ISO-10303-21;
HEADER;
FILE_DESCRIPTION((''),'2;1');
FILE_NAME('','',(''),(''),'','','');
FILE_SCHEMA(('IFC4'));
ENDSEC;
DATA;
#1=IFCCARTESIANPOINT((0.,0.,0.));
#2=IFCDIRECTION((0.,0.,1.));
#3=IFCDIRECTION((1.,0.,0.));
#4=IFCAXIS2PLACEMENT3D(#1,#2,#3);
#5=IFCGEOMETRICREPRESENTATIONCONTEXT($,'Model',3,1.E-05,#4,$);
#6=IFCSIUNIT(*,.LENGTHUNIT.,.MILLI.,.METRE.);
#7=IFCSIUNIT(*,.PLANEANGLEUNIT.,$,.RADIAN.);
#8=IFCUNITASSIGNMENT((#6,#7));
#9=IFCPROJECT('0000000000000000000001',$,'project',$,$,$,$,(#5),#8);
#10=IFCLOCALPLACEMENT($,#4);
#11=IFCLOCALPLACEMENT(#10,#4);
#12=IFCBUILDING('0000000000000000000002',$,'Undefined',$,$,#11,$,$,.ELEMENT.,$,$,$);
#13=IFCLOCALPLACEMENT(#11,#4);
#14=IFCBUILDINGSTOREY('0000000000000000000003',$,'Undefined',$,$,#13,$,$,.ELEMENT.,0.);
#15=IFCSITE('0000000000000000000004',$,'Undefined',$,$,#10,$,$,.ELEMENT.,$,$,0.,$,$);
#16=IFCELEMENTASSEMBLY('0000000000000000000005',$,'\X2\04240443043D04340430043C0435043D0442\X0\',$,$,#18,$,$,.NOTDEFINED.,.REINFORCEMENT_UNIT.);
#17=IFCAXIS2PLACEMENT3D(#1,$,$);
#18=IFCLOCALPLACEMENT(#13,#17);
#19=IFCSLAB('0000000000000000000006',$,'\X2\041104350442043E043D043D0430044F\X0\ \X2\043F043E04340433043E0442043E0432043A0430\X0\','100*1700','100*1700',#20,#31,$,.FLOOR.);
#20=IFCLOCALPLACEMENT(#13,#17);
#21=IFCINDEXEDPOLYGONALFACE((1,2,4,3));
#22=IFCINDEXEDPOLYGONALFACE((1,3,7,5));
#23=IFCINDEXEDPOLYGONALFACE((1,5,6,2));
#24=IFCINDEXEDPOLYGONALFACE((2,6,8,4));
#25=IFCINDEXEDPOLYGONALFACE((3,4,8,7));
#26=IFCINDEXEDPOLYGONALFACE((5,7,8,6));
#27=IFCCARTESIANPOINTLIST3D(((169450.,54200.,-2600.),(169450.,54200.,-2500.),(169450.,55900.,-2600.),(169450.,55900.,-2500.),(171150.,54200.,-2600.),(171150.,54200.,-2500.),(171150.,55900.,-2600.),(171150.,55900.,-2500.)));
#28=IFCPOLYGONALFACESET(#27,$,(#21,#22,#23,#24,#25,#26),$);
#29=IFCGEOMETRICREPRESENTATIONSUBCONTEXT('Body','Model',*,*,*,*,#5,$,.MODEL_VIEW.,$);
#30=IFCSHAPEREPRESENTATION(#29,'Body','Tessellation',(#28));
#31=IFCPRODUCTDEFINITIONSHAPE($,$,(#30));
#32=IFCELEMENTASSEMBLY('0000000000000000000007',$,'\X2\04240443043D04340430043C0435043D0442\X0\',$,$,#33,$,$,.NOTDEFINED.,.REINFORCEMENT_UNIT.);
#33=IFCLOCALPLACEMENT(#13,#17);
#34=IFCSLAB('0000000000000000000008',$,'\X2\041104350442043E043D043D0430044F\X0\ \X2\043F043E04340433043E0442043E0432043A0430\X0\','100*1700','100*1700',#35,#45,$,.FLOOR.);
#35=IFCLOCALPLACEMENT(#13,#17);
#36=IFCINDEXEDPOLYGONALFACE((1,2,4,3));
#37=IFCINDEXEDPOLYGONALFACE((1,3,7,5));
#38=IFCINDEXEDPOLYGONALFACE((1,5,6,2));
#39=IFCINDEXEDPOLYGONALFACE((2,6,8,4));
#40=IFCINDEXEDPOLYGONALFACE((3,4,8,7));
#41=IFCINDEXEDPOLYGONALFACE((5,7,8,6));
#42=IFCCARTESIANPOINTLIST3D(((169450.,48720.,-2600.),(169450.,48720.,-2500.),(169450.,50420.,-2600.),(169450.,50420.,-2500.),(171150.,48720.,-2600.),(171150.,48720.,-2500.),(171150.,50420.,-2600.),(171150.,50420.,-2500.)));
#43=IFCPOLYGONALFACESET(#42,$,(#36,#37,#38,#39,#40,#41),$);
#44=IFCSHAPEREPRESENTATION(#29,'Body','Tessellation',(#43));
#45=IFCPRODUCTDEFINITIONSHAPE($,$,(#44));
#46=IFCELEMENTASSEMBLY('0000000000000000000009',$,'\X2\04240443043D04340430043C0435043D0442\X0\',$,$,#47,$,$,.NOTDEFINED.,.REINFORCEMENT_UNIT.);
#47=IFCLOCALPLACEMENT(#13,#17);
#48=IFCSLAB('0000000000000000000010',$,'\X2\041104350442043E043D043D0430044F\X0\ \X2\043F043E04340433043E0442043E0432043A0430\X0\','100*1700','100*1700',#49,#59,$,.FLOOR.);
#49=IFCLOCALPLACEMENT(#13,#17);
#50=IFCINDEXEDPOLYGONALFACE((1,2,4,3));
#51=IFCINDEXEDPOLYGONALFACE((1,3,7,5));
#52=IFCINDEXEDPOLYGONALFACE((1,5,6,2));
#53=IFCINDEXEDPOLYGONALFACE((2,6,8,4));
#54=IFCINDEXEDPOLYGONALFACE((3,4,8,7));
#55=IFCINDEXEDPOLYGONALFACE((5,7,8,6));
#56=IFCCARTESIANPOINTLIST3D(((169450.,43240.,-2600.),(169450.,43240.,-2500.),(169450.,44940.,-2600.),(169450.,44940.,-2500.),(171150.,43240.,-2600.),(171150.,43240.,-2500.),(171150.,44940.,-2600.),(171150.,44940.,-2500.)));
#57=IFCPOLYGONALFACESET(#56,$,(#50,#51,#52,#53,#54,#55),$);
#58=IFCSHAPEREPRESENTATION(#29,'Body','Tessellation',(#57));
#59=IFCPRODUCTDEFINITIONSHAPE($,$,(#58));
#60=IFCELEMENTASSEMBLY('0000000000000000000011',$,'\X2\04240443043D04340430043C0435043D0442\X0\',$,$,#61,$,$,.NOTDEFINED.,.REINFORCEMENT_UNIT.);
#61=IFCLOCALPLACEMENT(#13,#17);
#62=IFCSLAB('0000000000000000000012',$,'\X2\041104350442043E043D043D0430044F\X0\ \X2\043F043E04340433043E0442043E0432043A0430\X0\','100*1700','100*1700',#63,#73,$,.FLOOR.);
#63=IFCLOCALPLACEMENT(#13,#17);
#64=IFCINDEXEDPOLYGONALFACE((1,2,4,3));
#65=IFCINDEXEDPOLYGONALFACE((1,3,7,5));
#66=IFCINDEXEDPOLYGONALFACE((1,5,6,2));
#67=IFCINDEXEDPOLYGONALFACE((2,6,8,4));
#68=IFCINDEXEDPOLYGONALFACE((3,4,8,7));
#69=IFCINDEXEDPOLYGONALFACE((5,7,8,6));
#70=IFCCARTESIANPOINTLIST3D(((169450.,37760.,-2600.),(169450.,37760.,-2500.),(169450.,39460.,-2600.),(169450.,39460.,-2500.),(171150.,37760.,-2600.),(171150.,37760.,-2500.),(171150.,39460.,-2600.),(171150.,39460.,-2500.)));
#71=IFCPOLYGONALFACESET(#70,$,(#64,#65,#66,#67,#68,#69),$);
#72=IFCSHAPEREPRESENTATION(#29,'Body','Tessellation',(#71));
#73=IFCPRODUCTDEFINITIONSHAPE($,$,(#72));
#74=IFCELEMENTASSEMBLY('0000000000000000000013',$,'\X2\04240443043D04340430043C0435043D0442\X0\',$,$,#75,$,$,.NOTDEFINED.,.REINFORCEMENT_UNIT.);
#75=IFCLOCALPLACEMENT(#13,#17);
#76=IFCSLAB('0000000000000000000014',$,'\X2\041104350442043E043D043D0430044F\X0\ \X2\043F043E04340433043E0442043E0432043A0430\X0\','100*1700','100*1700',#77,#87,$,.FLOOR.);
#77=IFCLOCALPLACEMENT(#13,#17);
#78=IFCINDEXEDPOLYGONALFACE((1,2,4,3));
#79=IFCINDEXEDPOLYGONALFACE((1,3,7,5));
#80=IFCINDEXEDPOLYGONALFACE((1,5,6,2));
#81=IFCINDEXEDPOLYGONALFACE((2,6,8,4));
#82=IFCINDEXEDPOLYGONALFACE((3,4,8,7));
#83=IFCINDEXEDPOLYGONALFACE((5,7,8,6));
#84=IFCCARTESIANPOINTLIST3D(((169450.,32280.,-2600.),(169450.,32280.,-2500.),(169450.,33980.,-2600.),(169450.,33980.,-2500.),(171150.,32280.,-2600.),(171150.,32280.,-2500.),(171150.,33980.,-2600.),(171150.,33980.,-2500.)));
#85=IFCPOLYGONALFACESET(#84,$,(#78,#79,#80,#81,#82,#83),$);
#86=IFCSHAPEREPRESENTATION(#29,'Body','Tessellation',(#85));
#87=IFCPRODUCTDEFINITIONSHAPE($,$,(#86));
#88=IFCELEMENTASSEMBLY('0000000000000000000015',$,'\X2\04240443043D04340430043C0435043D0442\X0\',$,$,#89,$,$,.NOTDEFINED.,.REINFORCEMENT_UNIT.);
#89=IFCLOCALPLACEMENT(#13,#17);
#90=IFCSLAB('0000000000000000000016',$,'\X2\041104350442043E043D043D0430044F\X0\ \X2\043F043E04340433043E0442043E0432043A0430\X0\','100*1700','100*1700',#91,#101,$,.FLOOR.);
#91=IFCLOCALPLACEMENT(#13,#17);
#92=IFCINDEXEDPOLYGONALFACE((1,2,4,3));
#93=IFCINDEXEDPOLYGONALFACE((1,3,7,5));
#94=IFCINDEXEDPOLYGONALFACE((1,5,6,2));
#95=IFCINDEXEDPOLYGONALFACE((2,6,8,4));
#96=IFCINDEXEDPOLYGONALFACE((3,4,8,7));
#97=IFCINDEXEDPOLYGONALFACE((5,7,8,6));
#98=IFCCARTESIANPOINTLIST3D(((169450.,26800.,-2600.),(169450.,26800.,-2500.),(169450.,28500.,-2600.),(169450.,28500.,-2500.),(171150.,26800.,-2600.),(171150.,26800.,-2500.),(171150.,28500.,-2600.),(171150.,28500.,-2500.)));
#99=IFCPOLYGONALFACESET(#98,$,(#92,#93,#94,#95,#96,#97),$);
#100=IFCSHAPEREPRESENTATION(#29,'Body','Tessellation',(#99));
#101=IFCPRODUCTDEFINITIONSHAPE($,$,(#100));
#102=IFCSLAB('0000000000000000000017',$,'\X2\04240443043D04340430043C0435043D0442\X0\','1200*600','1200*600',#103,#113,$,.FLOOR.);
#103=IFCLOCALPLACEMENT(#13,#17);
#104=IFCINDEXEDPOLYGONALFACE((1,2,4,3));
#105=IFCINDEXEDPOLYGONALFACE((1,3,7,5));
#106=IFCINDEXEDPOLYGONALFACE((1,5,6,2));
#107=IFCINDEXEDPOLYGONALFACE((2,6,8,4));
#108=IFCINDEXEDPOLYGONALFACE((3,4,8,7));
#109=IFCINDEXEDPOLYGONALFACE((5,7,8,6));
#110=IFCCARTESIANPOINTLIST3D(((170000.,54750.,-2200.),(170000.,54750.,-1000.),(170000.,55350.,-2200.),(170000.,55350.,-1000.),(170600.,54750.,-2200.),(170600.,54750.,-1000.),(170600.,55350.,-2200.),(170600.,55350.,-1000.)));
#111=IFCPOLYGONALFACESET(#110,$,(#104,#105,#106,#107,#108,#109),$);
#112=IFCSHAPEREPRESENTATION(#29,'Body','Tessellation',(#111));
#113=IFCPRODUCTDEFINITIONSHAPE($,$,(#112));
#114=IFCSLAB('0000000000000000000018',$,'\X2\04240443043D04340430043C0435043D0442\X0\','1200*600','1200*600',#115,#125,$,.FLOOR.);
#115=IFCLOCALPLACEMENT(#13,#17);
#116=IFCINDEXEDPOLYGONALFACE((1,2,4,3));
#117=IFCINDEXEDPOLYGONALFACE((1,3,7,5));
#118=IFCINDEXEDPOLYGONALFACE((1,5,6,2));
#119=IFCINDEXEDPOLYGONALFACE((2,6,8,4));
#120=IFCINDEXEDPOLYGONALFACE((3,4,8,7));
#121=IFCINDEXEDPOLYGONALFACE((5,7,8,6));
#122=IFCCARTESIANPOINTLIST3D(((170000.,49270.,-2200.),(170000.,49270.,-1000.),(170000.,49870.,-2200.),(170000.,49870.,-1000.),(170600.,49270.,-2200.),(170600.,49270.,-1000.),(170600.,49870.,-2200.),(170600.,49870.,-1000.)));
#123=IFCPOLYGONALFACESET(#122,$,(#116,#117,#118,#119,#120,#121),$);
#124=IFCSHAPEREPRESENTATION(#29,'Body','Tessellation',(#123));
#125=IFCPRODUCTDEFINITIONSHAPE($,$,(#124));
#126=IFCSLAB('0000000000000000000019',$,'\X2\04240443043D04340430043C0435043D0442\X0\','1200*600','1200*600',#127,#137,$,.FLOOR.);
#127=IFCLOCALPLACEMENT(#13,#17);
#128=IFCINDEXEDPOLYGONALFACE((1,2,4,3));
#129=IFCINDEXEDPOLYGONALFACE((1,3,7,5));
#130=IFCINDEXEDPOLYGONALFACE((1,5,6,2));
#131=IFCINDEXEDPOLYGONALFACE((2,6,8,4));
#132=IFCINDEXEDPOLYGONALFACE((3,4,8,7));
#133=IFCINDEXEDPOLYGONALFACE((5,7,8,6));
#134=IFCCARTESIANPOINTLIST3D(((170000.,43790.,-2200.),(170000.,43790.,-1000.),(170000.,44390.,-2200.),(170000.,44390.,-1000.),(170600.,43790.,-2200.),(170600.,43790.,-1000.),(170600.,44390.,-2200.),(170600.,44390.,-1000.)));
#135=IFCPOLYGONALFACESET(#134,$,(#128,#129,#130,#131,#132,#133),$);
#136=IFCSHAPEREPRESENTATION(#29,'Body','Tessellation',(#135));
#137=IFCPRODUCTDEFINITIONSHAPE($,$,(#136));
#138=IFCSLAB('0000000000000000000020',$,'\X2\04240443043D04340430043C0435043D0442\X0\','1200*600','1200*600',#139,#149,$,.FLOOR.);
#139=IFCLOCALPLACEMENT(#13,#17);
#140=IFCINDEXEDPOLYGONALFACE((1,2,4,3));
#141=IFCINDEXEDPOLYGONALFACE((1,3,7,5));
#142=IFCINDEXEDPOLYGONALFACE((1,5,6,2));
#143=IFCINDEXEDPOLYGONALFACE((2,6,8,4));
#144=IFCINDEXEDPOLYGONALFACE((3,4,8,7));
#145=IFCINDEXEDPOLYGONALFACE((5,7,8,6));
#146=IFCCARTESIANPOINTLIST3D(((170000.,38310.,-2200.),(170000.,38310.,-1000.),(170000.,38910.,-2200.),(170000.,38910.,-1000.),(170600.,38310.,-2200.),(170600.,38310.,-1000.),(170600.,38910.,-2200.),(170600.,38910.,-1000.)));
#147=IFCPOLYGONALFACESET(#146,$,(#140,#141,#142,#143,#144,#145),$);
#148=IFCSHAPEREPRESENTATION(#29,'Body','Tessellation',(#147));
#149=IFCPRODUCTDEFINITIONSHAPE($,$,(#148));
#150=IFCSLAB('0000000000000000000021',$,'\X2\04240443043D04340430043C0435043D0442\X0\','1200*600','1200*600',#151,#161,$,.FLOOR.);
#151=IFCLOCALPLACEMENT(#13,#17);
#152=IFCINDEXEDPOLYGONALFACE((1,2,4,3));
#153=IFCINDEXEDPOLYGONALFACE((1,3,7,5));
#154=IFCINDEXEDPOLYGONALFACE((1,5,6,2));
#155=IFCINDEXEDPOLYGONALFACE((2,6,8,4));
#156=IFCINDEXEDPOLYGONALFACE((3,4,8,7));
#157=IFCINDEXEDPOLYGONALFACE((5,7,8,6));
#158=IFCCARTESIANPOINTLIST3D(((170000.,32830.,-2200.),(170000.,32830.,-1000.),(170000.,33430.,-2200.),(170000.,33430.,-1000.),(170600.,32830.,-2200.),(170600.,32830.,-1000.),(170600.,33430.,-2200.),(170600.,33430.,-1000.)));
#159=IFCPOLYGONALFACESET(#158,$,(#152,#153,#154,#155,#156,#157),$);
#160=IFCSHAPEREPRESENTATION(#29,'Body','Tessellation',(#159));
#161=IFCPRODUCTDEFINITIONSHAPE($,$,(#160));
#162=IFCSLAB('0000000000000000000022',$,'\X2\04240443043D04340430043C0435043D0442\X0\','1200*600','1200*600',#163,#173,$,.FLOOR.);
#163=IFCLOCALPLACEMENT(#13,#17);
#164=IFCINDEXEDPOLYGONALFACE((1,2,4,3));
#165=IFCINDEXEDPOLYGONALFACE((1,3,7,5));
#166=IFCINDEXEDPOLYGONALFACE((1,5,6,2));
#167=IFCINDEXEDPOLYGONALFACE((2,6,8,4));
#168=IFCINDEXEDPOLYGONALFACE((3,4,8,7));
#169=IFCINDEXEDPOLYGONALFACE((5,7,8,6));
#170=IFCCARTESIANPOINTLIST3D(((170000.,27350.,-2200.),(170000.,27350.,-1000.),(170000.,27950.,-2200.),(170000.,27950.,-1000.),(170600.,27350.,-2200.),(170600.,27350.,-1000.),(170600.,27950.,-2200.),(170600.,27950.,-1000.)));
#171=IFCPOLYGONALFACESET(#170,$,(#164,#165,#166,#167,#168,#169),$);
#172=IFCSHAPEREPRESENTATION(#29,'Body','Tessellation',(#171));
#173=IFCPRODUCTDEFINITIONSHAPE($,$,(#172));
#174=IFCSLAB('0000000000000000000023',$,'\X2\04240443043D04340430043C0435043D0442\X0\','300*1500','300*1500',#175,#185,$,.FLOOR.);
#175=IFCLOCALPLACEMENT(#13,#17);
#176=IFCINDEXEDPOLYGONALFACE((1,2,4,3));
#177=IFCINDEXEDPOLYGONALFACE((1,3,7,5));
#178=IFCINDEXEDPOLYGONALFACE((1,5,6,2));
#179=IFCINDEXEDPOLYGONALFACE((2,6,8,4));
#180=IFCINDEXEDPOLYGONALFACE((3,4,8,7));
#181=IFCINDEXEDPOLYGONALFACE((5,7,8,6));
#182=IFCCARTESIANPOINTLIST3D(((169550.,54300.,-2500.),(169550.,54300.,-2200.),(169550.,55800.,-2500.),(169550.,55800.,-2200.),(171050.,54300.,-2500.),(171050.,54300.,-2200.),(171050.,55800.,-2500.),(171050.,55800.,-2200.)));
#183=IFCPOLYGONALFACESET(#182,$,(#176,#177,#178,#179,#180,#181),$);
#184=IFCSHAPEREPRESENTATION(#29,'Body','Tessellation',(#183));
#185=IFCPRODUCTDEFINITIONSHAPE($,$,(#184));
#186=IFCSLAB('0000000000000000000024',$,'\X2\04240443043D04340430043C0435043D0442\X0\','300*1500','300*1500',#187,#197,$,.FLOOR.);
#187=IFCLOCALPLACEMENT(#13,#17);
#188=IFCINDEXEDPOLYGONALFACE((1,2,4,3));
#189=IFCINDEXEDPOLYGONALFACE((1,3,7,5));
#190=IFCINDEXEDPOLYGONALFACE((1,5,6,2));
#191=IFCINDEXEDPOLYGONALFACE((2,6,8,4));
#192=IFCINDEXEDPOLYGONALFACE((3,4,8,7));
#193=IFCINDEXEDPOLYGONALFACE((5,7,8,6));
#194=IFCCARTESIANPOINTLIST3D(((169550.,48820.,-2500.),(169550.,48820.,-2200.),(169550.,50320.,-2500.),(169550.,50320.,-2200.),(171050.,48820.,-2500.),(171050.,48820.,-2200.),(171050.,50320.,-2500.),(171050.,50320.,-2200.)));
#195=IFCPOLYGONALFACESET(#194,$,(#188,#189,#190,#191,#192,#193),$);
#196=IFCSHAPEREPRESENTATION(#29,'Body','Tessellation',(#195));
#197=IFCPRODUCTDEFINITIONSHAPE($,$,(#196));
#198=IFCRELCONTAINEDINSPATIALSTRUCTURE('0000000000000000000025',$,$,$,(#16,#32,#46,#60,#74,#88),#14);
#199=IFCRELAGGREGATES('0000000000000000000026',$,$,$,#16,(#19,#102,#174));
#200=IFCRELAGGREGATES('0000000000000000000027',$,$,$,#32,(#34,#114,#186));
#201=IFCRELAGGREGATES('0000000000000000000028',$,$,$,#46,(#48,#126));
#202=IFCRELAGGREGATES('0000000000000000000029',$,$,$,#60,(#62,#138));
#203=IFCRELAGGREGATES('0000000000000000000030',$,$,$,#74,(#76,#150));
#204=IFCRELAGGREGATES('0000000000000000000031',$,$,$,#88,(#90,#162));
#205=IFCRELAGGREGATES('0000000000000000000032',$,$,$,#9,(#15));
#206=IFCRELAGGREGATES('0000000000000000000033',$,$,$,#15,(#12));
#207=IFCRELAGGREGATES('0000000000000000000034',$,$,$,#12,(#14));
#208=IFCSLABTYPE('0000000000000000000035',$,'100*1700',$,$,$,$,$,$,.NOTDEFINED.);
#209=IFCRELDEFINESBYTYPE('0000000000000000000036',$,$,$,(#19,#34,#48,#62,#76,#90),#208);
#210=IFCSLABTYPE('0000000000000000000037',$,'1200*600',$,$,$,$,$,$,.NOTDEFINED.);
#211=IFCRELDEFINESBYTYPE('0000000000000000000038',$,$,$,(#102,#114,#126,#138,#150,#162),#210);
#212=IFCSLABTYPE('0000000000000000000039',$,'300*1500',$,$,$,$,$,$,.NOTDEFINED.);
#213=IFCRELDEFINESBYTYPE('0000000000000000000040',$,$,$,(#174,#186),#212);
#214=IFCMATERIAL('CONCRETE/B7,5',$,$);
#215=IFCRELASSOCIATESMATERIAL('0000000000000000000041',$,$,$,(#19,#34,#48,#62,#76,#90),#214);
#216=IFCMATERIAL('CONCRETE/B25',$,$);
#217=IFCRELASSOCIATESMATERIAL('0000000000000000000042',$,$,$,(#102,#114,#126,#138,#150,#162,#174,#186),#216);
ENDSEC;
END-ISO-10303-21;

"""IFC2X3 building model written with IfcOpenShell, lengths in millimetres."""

from ifc_helpers import new_model, si_unit, frame, origin_with_axes, place, context, subcontext, project, spatial, polyline, outline, extrude, material, type_object, element, aggregate, save


model = new_model("IFC2X3")

# Units and contexts
model_context = context("Model", 3, precision=1e-05, world=origin_with_axes())
body_context = subcontext(model_context, "Body", "Model", "MODEL_VIEW")
ifc_project = project(units=[si_unit("LENGTHUNIT", "METRE", prefix="MILLI"), si_unit("PLANEANGLEUNIT", "RADIAN")], contexts=[model_context])

# Site, building, storey
site_placement = place(None, origin_with_axes())
site = spatial("IfcSite", under=ifc_project, at=site_placement, Name="Undefined", CompositionType="ELEMENT", RefElevation=0.0)
building_placement = place(site_placement, origin_with_axes())
building = spatial("IfcBuilding", under=site, at=building_placement, Name="Undefined", CompositionType="ELEMENT")
storey_placement = place(building_placement, origin_with_axes())
storey = spatial("IfcBuildingStorey", under=building, at=storey_placement, Name="Undefined", CompositionType="ELEMENT", Elevation=0.0)

# Element assemblies, slabs
assembly_1_placement = place(storey_placement, origin_with_axes())
assembly_1 = element("IfcElementAssembly", 1, at=assembly_1_placement, inside=storey, Name="Фундамент", AssemblyPlace="NOTDEFINED", PredefinedType="REINFORCEMENT_UNIT")
ifc_material_1 = material(Name="CONCRETE/B7,5")
slab_type_1 = type_object("IfcSlabType", Name="100*1700", PredefinedType="NOTDEFINED")
slab_1_placement = place(assembly_1_placement, frame((169450.0, 55900.0, -2550.0), z_axis=(0.0, 0.0, 1.0), x_axis=(0.0, -1.0, 0.0)))
slab_1 = element("IfcSlab", 2, at=slab_1_placement, type_object=slab_type_1, material=ifc_material_1, Name="Бетонная подготовка", Description="100*1700", ObjectType="100*1700", PredefinedType="FLOOR", context=body_context, shape_type="SweptSolid", body=[
    extrude(outline(polyline([(0.0, 0.0), (1700.0, 0.0), (1700.0, 1700.0), (0.0, 1700.0), (0.0, 0.0)])), frame((0.0, 0.0, -50.0), z_axis=(0.0, 0.0, 1.0), x_axis=(1.0, 0.0, 0.0)), (0.0, 0.0, 1.0), 100.0),
])
assembly_2_placement = place(storey_placement, origin_with_axes())
assembly_2 = element("IfcElementAssembly", 3, at=assembly_2_placement, inside=storey, Name="Фундамент", AssemblyPlace="NOTDEFINED", PredefinedType="REINFORCEMENT_UNIT")
slab_2_placement = place(assembly_2_placement, frame((169450.0, 50420.0, -2550.0), z_axis=(0.0, 0.0, 1.0), x_axis=(0.0, -1.0, 0.0)))
slab_2 = element("IfcSlab", 4, at=slab_2_placement, type_object=slab_type_1, material=ifc_material_1, Name="Бетонная подготовка", Description="100*1700", ObjectType="100*1700", PredefinedType="FLOOR", context=body_context, shape_type="SweptSolid", body=[
    extrude(outline(polyline([(0.0, 0.0), (1700.0, 0.0), (1700.0, 1700.0), (0.0, 1700.0), (0.0, 0.0)])), frame((0.0, 0.0, -50.0), z_axis=(0.0, 0.0, 1.0), x_axis=(1.0, 0.0, 0.0)), (0.0, 0.0, 1.0), 100.0),
])
assembly_3_placement = place(storey_placement, origin_with_axes())
assembly_3 = element("IfcElementAssembly", 5, at=assembly_3_placement, inside=storey, Name="Фундамент", AssemblyPlace="NOTDEFINED", PredefinedType="REINFORCEMENT_UNIT")
slab_3_placement = place(assembly_3_placement, frame((169450.0, 44940.0, -2550.0), z_axis=(0.0, 0.0, 1.0), x_axis=(0.0, -1.0, 0.0)))
slab_3 = element("IfcSlab", 6, at=slab_3_placement, type_object=slab_type_1, material=ifc_material_1, Name="Бетонная подготовка", Description="100*1700", ObjectType="100*1700", PredefinedType="FLOOR", context=body_context, shape_type="SweptSolid", body=[
    extrude(outline(polyline([(0.0, 0.0), (1700.0, 0.0), (1700.0, 1700.0), (0.0, 1700.0), (0.0, 0.0)])), frame((0.0, 0.0, -50.0), z_axis=(0.0, 0.0, 1.0), x_axis=(1.0, 0.0, 0.0)), (0.0, 0.0, 1.0), 100.0),
])
assembly_4_placement = place(storey_placement, origin_with_axes())
assembly_4 = element("IfcElementAssembly", 7, at=assembly_4_placement, inside=storey, Name="Фундамент", AssemblyPlace="NOTDEFINED", PredefinedType="REINFORCEMENT_UNIT")
slab_4_placement = place(assembly_4_placement, frame((169450.0, 39460.0, -2550.0), z_axis=(0.0, 0.0, 1.0), x_axis=(0.0, -1.0, 0.0)))
slab_4 = element("IfcSlab", 8, at=slab_4_placement, type_object=slab_type_1, material=ifc_material_1, Name="Бетонная подготовка", Description="100*1700", ObjectType="100*1700", PredefinedType="FLOOR", context=body_context, shape_type="SweptSolid", body=[
    extrude(outline(polyline([(0.0, 0.0), (1700.0, 0.0), (1700.0, 1700.0), (0.0, 1700.0), (0.0, 0.0)])), frame((0.0, 0.0, -50.0), z_axis=(0.0, 0.0, 1.0), x_axis=(1.0, 0.0, 0.0)), (0.0, 0.0, 1.0), 100.0),
])
assembly_5_placement = place(storey_placement, origin_with_axes())
assembly_5 = element("IfcElementAssembly", 9, at=assembly_5_placement, inside=storey, Name="Фундамент", AssemblyPlace="NOTDEFINED", PredefinedType="REINFORCEMENT_UNIT")
slab_5_placement = place(assembly_5_placement, frame((169450.0, 33980.0, -2550.0), z_axis=(0.0, 0.0, 1.0), x_axis=(0.0, -1.0, 0.0)))
slab_5 = element("IfcSlab", 10, at=slab_5_placement, type_object=slab_type_1, material=ifc_material_1, Name="Бетонная подготовка", Description="100*1700", ObjectType="100*1700", PredefinedType="FLOOR", context=body_context, shape_type="SweptSolid", body=[
    extrude(outline(polyline([(0.0, 0.0), (1700.0, 0.0), (1700.0, 1700.0), (0.0, 1700.0), (0.0, 0.0)])), frame((0.0, 0.0, -50.0), z_axis=(0.0, 0.0, 1.0), x_axis=(1.0, 0.0, 0.0)), (0.0, 0.0, 1.0), 100.0),
])
assembly_6_placement = place(storey_placement, origin_with_axes())
assembly_6 = element("IfcElementAssembly", 11, at=assembly_6_placement, inside=storey, Name="Фундамент", AssemblyPlace="NOTDEFINED", PredefinedType="REINFORCEMENT_UNIT")
slab_6_placement = place(assembly_6_placement, frame((169450.0, 28500.0, -2550.0), z_axis=(0.0, 0.0, 1.0), x_axis=(0.0, -1.0, 0.0)))
slab_6 = element("IfcSlab", 12, at=slab_6_placement, type_object=slab_type_1, material=ifc_material_1, Name="Бетонная подготовка", Description="100*1700", ObjectType="100*1700", PredefinedType="FLOOR", context=body_context, shape_type="SweptSolid", body=[
    extrude(outline(polyline([(0.0, 0.0), (1700.0, 0.0), (1700.0, 1700.0), (0.0, 1700.0), (0.0, 0.0)])), frame((0.0, 0.0, -50.0), z_axis=(0.0, 0.0, 1.0), x_axis=(1.0, 0.0, 0.0)), (0.0, 0.0, 1.0), 100.0),
])

# Slabs
ifc_material_2 = material(Name="CONCRETE/B25")
slab_type_2 = type_object("IfcSlabType", Name="1200*600", PredefinedType="NOTDEFINED")
slab_7_placement = place(assembly_1_placement, frame((170000.0, 55350.0, -1600.0), z_axis=(0.0, 0.0, 1.0), x_axis=(0.0, -1.0, 0.0)))
slab_7 = element("IfcSlab", 13, at=slab_7_placement, type_object=slab_type_2, material=ifc_material_2, Name="Фундамент", Description="1200*600", ObjectType="1200*600", PredefinedType="FLOOR", context=body_context, shape_type="SweptSolid", body=[
    extrude(outline(polyline([(0.0, 0.0), (600.0, 0.0), (600.0, 600.0), (0.0, 600.0), (0.0, 0.0)])), frame((0.0, 0.0, -600.0), z_axis=(0.0, 0.0, 1.0), x_axis=(1.0, 0.0, 0.0)), (0.0, 0.0, 1.0), 1200.0),
])
slab_8_placement = place(assembly_2_placement, frame((170000.0, 49870.0, -1600.0), z_axis=(0.0, 0.0, 1.0), x_axis=(0.0, -1.0, 0.0)))
slab_8 = element("IfcSlab", 14, at=slab_8_placement, type_object=slab_type_2, material=ifc_material_2, Name="Фундамент", Description="1200*600", ObjectType="1200*600", PredefinedType="FLOOR", context=body_context, shape_type="SweptSolid", body=[
    extrude(outline(polyline([(0.0, 0.0), (600.0, 0.0), (600.0, 600.0), (0.0, 600.0), (0.0, 0.0)])), frame((0.0, 0.0, -600.0), z_axis=(0.0, 0.0, 1.0), x_axis=(1.0, 0.0, 0.0)), (0.0, 0.0, 1.0), 1200.0),
])
slab_9_placement = place(assembly_3_placement, frame((170000.0, 44390.0, -1600.0), z_axis=(0.0, 0.0, 1.0), x_axis=(0.0, -1.0, 0.0)))
slab_9 = element("IfcSlab", 15, at=slab_9_placement, type_object=slab_type_2, material=ifc_material_2, Name="Фундамент", Description="1200*600", ObjectType="1200*600", PredefinedType="FLOOR", context=body_context, shape_type="SweptSolid", body=[
    extrude(outline(polyline([(0.0, 0.0), (600.0, 0.0), (600.0, 600.0), (0.0, 600.0), (0.0, 0.0)])), frame((0.0, 0.0, -600.0), z_axis=(0.0, 0.0, 1.0), x_axis=(1.0, 0.0, 0.0)), (0.0, 0.0, 1.0), 1200.0),
])
slab_10_placement = place(assembly_4_placement, frame((170000.0, 38910.0, -1600.0), z_axis=(0.0, 0.0, 1.0), x_axis=(0.0, -1.0, 0.0)))
slab_10 = element("IfcSlab", 16, at=slab_10_placement, type_object=slab_type_2, material=ifc_material_2, Name="Фундамент", Description="1200*600", ObjectType="1200*600", PredefinedType="FLOOR", context=body_context, shape_type="SweptSolid", body=[
    extrude(outline(polyline([(0.0, 0.0), (600.0, 0.0), (600.0, 600.0), (0.0, 600.0), (0.0, 0.0)])), frame((0.0, 0.0, -600.0), z_axis=(0.0, 0.0, 1.0), x_axis=(1.0, 0.0, 0.0)), (0.0, 0.0, 1.0), 1200.0),
])
slab_11_placement = place(assembly_5_placement, frame((170000.0, 33430.0, -1600.0), z_axis=(0.0, 0.0, 1.0), x_axis=(0.0, -1.0, 0.0)))
slab_11 = element("IfcSlab", 17, at=slab_11_placement, type_object=slab_type_2, material=ifc_material_2, Name="Фундамент", Description="1200*600", ObjectType="1200*600", PredefinedType="FLOOR", context=body_context, shape_type="SweptSolid", body=[
    extrude(outline(polyline([(0.0, 0.0), (600.0, 0.0), (600.0, 600.0), (0.0, 600.0), (0.0, 0.0)])), frame((0.0, 0.0, -600.0), z_axis=(0.0, 0.0, 1.0), x_axis=(1.0, 0.0, 0.0)), (0.0, 0.0, 1.0), 1200.0),
])
slab_12_placement = place(assembly_6_placement, frame((170000.0, 27950.0, -1600.0), z_axis=(0.0, 0.0, 1.0), x_axis=(0.0, -1.0, 0.0)))
slab_12 = element("IfcSlab", 18, at=slab_12_placement, type_object=slab_type_2, material=ifc_material_2, Name="Фундамент", Description="1200*600", ObjectType="1200*600", PredefinedType="FLOOR", context=body_context, shape_type="SweptSolid", body=[
    extrude(outline(polyline([(0.0, 0.0), (600.0, 0.0), (600.0, 600.0), (0.0, 600.0), (0.0, 0.0)])), frame((0.0, 0.0, -600.0), z_axis=(0.0, 0.0, 1.0), x_axis=(1.0, 0.0, 0.0)), (0.0, 0.0, 1.0), 1200.0),
])
slab_type_3 = type_object("IfcSlabType", Name="300*1500", PredefinedType="NOTDEFINED")
slab_13_placement = place(assembly_1_placement, frame((169550.0, 55800.0, -2350.0), z_axis=(0.0, 0.0, 1.0), x_axis=(0.0, -1.0, 0.0)))
slab_13 = element("IfcSlab", 19, at=slab_13_placement, type_object=slab_type_3, material=ifc_material_2, Name="Фундамент", Description="300*1500", ObjectType="300*1500", PredefinedType="FLOOR", context=body_context, shape_type="SweptSolid", body=[
    extrude(outline(polyline([(0.0, 0.0), (1500.0, 0.0), (1500.0, 1500.0), (0.0, 1500.0), (0.0, 0.0)])), frame((0.0, 0.0, -150.0), z_axis=(0.0, 0.0, 1.0), x_axis=(1.0, 0.0, 0.0)), (0.0, 0.0, 1.0), 300.0),
])
aggregate(assembly_1, [slab_1, slab_7, slab_13])
slab_14_placement = place(assembly_2_placement, frame((169550.0, 50320.0, -2350.0), z_axis=(0.0, 0.0, 1.0), x_axis=(0.0, -1.0, 0.0)))
slab_14 = element("IfcSlab", 20, at=slab_14_placement, type_object=slab_type_3, material=ifc_material_2, Name="Фундамент", Description="300*1500", ObjectType="300*1500", PredefinedType="FLOOR", context=body_context, shape_type="SweptSolid", body=[
    extrude(outline(polyline([(0.0, 0.0), (1500.0, 0.0), (1500.0, 1500.0), (0.0, 1500.0), (0.0, 0.0)])), frame((0.0, 0.0, -150.0), z_axis=(0.0, 0.0, 1.0), x_axis=(1.0, 0.0, 0.0)), (0.0, 0.0, 1.0), 300.0),
])
aggregate(assembly_2, [slab_2, slab_8, slab_14])
aggregate(assembly_3, [slab_3, slab_9])
aggregate(assembly_4, [slab_4, slab_10])
aggregate(assembly_5, [slab_5, slab_11])
aggregate(assembly_6, [slab_6, slab_12])

save(model, "model.ifc")
